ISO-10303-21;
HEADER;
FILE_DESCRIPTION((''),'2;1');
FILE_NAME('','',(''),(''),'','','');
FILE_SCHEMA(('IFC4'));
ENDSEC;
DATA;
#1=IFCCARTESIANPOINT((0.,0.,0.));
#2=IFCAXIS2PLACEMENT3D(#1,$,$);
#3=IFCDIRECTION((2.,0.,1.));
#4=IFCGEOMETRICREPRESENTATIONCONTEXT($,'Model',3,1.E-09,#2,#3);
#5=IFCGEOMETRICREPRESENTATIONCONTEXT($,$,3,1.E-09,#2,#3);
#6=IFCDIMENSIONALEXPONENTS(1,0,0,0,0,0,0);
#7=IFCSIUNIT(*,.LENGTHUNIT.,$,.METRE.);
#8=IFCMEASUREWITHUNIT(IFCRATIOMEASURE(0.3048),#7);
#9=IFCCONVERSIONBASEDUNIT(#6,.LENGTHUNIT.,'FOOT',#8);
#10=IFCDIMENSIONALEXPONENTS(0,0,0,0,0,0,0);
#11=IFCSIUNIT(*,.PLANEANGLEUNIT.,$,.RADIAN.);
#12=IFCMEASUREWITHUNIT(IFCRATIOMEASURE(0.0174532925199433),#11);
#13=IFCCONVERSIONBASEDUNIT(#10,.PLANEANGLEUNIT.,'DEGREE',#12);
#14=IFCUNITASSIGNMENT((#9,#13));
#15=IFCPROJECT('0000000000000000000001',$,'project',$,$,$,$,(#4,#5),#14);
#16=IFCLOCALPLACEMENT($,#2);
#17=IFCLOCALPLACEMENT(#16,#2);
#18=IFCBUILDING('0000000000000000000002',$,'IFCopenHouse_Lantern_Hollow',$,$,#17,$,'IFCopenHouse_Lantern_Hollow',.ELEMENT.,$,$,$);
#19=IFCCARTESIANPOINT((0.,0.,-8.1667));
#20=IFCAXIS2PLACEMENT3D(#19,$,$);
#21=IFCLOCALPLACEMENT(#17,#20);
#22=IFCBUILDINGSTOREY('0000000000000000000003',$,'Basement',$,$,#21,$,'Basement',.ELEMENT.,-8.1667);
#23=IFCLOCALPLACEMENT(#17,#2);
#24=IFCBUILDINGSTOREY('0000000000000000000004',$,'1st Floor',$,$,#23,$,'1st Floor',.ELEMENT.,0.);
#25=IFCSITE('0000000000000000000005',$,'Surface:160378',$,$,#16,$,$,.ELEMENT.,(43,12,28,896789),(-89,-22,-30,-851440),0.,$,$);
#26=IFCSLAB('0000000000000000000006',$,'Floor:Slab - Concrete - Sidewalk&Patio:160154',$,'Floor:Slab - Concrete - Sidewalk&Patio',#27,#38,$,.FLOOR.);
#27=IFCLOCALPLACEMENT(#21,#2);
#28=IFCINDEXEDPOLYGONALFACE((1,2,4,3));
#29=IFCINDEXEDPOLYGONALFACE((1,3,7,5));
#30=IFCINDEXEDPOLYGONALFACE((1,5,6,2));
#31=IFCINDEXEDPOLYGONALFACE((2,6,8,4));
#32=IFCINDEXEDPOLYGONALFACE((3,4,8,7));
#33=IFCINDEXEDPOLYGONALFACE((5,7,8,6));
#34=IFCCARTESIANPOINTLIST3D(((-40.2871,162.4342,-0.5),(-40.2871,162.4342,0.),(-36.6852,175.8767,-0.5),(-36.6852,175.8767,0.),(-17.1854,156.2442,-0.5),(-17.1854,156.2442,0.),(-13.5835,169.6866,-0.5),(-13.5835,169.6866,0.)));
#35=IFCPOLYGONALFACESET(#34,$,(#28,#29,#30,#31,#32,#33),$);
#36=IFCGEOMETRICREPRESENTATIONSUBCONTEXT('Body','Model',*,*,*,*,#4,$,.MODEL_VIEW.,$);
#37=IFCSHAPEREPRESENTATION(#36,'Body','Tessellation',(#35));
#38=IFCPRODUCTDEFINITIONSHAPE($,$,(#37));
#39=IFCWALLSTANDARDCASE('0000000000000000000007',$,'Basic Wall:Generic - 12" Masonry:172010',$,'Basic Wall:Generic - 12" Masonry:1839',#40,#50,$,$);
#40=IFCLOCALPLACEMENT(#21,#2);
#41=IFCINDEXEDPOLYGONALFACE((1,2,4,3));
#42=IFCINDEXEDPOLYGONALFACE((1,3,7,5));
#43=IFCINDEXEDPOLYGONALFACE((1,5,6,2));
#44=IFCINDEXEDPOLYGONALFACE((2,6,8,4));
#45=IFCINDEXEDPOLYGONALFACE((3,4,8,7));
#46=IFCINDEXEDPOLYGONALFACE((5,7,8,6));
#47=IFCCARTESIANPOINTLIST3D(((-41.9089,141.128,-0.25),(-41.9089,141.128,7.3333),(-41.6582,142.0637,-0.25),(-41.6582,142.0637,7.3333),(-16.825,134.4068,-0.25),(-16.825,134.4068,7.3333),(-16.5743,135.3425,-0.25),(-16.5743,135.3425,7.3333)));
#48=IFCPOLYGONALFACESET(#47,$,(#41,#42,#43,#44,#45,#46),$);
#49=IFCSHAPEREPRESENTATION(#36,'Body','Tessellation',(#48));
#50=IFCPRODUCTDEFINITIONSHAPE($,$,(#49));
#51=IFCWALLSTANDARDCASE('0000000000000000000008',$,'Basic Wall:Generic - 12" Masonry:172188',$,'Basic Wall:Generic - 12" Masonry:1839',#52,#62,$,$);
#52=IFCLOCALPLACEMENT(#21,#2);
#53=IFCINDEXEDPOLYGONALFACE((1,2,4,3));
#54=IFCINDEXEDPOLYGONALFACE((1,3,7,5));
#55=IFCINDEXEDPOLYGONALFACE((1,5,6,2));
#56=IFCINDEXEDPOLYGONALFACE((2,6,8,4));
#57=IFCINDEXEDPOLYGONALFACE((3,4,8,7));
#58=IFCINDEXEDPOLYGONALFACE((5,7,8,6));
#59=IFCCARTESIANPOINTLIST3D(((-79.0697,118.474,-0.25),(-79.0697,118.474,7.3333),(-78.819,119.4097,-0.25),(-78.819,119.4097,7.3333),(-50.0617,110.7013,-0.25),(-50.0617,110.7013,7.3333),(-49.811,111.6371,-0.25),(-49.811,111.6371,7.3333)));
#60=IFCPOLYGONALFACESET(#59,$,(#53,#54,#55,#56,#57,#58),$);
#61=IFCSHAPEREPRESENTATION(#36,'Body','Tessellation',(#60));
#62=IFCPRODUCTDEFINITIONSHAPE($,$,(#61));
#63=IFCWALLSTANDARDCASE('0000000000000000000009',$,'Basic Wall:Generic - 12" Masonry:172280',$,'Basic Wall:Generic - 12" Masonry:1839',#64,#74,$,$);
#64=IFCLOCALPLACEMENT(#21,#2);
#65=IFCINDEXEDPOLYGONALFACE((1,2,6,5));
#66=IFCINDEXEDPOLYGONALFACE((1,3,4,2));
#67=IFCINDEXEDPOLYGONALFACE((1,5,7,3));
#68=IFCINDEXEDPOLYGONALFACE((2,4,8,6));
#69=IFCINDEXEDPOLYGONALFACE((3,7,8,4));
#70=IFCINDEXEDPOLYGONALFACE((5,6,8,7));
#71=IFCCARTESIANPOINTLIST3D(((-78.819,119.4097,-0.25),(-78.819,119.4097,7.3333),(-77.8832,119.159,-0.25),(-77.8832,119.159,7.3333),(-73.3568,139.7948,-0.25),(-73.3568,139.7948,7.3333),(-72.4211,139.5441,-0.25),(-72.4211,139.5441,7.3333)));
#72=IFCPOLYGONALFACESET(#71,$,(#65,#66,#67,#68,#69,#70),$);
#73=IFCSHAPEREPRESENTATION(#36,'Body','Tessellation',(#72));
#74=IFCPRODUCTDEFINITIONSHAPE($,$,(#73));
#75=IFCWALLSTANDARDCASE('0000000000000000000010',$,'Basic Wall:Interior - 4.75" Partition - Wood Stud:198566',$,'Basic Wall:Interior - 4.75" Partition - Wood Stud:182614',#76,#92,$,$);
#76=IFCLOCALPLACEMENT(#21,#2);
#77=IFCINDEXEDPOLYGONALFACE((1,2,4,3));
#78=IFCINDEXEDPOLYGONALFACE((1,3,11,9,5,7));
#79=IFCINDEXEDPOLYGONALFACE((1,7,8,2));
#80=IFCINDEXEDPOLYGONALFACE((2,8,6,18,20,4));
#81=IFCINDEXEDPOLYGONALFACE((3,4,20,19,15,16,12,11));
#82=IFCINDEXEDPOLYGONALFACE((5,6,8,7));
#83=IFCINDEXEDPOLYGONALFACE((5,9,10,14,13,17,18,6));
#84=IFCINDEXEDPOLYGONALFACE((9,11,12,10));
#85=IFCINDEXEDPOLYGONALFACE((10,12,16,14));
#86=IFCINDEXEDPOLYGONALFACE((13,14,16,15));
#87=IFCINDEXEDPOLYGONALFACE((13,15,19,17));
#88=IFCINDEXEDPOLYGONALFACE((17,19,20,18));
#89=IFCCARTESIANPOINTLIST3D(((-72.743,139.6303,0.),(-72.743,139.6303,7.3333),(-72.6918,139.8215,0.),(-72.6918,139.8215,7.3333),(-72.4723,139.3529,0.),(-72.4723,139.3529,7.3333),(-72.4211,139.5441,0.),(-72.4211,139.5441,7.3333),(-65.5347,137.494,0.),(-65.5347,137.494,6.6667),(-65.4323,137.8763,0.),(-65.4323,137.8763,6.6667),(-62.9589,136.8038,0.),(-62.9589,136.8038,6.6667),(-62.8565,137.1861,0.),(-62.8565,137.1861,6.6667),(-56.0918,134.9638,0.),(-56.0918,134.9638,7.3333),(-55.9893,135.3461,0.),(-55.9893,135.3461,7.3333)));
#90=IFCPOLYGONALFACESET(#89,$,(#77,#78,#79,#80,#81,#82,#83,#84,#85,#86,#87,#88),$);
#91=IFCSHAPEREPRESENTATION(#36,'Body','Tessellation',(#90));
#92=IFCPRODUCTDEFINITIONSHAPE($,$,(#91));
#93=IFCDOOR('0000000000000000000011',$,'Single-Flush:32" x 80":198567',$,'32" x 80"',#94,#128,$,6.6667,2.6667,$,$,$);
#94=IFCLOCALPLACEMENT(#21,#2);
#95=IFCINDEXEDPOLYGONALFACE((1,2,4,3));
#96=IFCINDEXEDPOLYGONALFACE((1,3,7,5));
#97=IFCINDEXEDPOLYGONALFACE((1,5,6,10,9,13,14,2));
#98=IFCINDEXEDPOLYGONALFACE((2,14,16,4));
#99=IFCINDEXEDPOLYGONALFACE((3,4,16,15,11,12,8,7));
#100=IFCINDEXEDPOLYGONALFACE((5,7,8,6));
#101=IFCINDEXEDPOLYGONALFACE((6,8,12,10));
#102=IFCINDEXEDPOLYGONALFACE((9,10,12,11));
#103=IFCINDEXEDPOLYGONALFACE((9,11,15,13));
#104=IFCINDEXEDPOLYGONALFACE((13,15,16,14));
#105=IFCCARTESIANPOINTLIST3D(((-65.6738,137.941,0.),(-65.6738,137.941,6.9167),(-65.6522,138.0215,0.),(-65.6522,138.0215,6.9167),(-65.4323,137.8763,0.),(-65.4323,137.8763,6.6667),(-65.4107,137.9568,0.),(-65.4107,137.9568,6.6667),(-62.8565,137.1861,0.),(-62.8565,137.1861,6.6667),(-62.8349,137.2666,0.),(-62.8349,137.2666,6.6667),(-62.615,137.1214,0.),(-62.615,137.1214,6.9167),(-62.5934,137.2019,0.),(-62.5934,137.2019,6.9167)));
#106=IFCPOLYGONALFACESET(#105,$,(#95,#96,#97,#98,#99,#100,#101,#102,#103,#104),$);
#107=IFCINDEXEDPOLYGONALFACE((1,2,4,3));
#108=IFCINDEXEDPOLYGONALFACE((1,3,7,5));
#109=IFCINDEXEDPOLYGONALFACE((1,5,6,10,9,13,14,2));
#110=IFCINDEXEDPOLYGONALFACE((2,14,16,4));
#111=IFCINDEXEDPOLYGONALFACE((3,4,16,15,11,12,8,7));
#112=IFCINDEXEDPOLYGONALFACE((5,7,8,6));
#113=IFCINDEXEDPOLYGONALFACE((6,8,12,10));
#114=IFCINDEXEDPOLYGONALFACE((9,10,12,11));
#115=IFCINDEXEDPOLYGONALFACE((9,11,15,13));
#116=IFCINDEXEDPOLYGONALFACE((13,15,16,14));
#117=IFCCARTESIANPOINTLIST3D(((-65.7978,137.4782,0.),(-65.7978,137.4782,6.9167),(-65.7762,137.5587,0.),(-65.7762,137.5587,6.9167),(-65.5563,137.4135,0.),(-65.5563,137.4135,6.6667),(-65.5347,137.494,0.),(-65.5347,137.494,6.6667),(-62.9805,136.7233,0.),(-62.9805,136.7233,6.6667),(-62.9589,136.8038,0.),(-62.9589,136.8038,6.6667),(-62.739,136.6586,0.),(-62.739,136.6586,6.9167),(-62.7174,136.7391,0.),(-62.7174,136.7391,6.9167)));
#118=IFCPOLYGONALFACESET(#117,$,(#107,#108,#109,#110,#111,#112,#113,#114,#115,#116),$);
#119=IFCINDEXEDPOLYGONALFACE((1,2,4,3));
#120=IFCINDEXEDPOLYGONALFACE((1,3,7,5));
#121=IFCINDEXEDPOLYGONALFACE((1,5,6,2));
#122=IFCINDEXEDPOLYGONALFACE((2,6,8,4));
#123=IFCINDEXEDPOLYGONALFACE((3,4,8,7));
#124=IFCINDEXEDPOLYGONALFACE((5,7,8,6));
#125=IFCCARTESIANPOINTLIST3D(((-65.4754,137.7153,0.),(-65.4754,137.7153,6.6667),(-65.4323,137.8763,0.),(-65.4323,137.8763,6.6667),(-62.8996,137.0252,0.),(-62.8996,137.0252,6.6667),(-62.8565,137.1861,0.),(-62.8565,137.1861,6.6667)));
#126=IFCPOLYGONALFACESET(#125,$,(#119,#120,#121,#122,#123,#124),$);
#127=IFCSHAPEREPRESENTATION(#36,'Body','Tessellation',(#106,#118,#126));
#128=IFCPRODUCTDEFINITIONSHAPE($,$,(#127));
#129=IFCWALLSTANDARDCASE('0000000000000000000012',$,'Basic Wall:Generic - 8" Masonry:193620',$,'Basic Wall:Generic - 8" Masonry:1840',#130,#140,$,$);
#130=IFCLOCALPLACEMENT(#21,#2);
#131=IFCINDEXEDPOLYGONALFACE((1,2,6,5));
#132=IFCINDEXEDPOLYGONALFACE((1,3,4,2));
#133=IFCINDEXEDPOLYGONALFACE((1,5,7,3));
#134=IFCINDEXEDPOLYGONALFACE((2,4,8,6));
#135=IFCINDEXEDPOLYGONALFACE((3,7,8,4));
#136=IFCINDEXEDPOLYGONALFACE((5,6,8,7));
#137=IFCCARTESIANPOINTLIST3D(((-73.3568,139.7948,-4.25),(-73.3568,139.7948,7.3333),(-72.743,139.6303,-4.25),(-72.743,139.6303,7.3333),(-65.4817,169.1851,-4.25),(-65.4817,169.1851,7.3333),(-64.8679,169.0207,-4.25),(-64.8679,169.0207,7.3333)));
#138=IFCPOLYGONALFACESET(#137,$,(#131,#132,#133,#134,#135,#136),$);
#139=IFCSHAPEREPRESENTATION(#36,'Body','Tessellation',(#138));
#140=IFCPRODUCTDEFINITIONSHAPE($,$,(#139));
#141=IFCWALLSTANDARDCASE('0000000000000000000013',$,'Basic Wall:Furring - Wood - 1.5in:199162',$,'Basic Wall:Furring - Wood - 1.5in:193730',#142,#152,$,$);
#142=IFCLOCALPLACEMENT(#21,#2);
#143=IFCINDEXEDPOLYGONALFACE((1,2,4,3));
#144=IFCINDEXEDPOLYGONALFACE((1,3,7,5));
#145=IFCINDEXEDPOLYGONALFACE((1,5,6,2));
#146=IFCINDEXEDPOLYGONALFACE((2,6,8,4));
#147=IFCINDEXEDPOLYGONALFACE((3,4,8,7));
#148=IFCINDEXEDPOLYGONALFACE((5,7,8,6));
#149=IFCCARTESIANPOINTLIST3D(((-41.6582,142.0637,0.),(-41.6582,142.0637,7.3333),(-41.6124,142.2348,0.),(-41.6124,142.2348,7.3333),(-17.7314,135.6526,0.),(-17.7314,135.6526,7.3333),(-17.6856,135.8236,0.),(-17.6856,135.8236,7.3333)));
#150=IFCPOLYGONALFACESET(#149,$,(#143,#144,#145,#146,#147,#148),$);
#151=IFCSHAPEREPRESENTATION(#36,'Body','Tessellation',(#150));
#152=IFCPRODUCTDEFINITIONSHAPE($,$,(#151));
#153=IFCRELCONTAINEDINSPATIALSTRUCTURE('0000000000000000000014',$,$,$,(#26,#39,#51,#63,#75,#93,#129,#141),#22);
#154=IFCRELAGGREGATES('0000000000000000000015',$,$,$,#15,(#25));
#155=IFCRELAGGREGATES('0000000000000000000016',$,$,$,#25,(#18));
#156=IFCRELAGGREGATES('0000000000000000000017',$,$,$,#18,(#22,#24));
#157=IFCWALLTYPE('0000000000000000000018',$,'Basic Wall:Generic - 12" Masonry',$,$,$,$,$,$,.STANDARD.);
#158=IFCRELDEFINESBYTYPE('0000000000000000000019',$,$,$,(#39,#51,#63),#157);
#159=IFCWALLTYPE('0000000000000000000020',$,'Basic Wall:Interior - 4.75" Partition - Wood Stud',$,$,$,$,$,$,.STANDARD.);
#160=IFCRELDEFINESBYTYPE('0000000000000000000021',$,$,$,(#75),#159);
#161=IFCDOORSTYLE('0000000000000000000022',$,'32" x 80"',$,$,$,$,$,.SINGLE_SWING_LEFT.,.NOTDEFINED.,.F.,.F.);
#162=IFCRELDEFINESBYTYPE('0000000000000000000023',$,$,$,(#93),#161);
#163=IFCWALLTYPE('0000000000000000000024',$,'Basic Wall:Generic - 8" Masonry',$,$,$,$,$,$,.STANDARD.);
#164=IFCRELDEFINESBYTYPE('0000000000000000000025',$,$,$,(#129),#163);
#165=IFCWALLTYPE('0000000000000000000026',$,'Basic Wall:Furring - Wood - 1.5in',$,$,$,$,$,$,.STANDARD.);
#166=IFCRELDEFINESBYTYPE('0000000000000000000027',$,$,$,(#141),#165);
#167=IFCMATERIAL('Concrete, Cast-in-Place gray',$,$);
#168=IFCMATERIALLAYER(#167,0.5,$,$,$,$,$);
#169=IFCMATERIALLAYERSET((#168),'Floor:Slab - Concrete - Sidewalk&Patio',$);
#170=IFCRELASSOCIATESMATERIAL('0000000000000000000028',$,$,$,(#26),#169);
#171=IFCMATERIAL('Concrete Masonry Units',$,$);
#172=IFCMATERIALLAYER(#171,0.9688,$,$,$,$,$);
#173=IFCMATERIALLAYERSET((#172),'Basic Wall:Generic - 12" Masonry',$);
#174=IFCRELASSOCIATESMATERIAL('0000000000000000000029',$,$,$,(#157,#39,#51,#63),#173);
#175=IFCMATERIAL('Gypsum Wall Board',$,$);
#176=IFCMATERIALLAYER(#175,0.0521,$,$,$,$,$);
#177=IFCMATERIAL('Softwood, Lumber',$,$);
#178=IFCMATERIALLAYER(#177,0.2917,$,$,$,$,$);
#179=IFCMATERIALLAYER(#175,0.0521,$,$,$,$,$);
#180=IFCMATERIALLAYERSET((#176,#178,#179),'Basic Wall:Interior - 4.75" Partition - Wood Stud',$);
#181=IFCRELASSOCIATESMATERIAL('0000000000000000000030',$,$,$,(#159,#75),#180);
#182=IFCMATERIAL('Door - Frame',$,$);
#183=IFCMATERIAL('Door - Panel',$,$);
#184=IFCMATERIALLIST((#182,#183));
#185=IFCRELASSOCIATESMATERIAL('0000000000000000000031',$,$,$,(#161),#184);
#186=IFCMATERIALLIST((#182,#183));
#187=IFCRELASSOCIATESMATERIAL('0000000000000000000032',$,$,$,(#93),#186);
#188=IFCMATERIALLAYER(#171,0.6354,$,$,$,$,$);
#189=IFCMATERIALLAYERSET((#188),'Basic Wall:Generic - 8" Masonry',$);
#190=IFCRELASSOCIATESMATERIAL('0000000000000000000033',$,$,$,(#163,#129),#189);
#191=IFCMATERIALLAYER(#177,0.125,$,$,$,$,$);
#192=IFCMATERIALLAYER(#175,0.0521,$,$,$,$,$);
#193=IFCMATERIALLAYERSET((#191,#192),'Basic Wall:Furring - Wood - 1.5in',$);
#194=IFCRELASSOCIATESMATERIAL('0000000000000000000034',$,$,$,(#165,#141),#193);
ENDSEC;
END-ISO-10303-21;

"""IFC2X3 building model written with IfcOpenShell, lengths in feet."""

from ifc_helpers import new_model, entity, si_unit, converted_unit, direction, frame, frame_2d, origin, origin_2d_with_axis, place, context, subcontext, project, spatial, polyline, rectangle, outline, extrude, source, transform, mapped, material, material_list, layer, layer_set, layer_usage, type_object, type_shapes, element, fill, save


model = new_model("IFC2X3")

# Units and contexts
model_context = context("Model", 3, precision=1e-09, world=origin(), true_north=direction((2.0, 0.0, 1.0)))
context_of_model = context(None, 3, precision=1e-09, world=origin(), true_north=direction((2.0, 0.0, 1.0)))
body_context = subcontext(model_context, "Body", "Model", "MODEL_VIEW")
ifc_project = project(units=[converted_unit("LENGTHUNIT", "FOOT", entity("IfcRatioMeasure", 0.3048), si_unit("LENGTHUNIT", "METRE"), dimensions=[1, 0, 0, 0, 0, 0, 0]), converted_unit("PLANEANGLEUNIT", "DEGREE", entity("IfcRatioMeasure", 0.0174532925199433), si_unit("PLANEANGLEUNIT", "RADIAN"), dimensions=[0, 0, 0, 0, 0, 0, 0])], contexts=[model_context, context_of_model])

# Site, building, storey
site_placement = place(None, origin())
site = spatial("IfcSite", under=ifc_project, at=site_placement, Name="Surface:160378", CompositionType="ELEMENT", RefLatitude=(43, 12, 28, 896789), RefLongitude=(-89, -22, -30, -851440), RefElevation=0.0)
building_placement = place(site_placement, origin())
building = spatial("IfcBuilding", under=site, at=building_placement, Name="IFCopenHouse_Lantern_Hollow", LongName="IFCopenHouse_Lantern_Hollow", CompositionType="ELEMENT")
storey_1_placement = place(building_placement, frame((0.0, 0.0, -8.1667)))
storey_1 = spatial("IfcBuildingStorey", under=building, at=storey_1_placement, Name="Basement", LongName="Basement", CompositionType="ELEMENT", Elevation=-8.1667)

# Shared definitions
ifc_material_1 = material(Name="Concrete, Cast-in-Place gray")

# Slab
ifc_layer_1 = layer(ifc_material_1, 0.5)
ifc_layer_set_1 = layer_set([ifc_layer_1], Name="Floor:Slab - Concrete - Sidewalk&Patio")
ifc_layer_usage_1 = layer_usage(ifc_layer_set_1, "AXIS3", "POSITIVE", 0.0)
slab_1_placement = place(storey_1_placement, origin())
element("IfcSlab", 1, at=slab_1_placement, inside=storey_1, material=ifc_layer_usage_1, Name="Floor:Slab - Concrete - Sidewalk&Patio:160154", ObjectType="Floor:Slab - Concrete - Sidewalk&Patio", PredefinedType="FLOOR", context=body_context, shape_type="SweptSolid", body=[
    extrude(rectangle(XDim=13.9167, YDim=23.9167, at=frame_2d((0.0, 0.0), x_axis=(1.0, 0.0))), frame((-26.9353, 166.0604, 0.0), z_axis=(0.0, 0.0, -1.0), x_axis=(-0.258819, -0.965926, 0.0)), (0.0, 0.0, 1.0), 0.5),
])

# Walls
ifc_material_2 = material(Name="Concrete Masonry Units")
ifc_layer_2 = layer(ifc_material_2, 0.9688)
ifc_layer_set_2 = layer_set([ifc_layer_2], Name="Basic Wall:Generic - 12\" Masonry")
ifc_layer_usage_2 = layer_usage(ifc_layer_set_2, "AXIS2", "NEGATIVE", 0.4844)
wall_type_1 = type_object("IfcWallType", Name="Basic Wall:Generic - 12\" Masonry", PredefinedType="STANDARD", material=ifc_layer_set_2)
wall_1_placement = place(storey_1_placement, frame((-16.6997, 134.8747, -0.25), z_axis=(0.0, 0.0, 1.0), x_axis=(-0.965926, 0.258819, 0.0)))
element("IfcWallStandardCase", 2, at=wall_1_placement, inside=storey_1, type_object=wall_type_1, material=ifc_layer_usage_2, Name="Basic Wall:Generic - 12\" Masonry:172010", ObjectType="Basic Wall:Generic - 12\" Masonry:1839", context=body_context, shape_type="SweptSolid", body=[
    extrude(rectangle(XDim=25.9687, YDim=0.9688, at=frame_2d((12.9844, 0.0), x_axis=(-1.0, 0.0))), origin(), (0.0, 0.0, 1.0), 7.5833),
])
ifc_layer_usage_3 = layer_usage(ifc_layer_set_2, "AXIS2", "NEGATIVE", 0.4844)
wall_2_placement = place(storey_1_placement, frame((-49.9364, 111.1692, -0.25), z_axis=(0.0, 0.0, 1.0), x_axis=(-0.965926, 0.258819, 0.0)))
element("IfcWallStandardCase", 3, at=wall_2_placement, inside=storey_1, type_object=wall_type_1, material=ifc_layer_usage_3, Name="Basic Wall:Generic - 12\" Masonry:172188", ObjectType="Basic Wall:Generic - 12\" Masonry:1839", context=body_context, shape_type="SweptSolid", body=[
    extrude(rectangle(XDim=30.0313, YDim=0.9687, at=frame_2d((15.0156, 0.0), x_axis=(-1.0, 0.0))), origin(), (0.0, 0.0, 1.0), 7.5833),
])
ifc_layer_usage_4 = layer_usage(ifc_layer_set_2, "AXIS2", "NEGATIVE", 0.4844)
wall_3_placement = place(storey_1_placement, frame((-78.3511, 119.2844, -0.25), z_axis=(0.0, 0.0, 1.0), x_axis=(0.258819, 0.965926, 0.0)))
element("IfcWallStandardCase", 4, at=wall_3_placement, inside=storey_1, type_object=wall_type_1, material=ifc_layer_usage_4, Name="Basic Wall:Generic - 12\" Masonry:172280", ObjectType="Basic Wall:Generic - 12\" Masonry:1839", context=body_context, shape_type="SweptSolid", body=[
    extrude(rectangle(XDim=21.1042, YDim=0.9687, at=frame_2d((10.5521, 0.0), x_axis=(-1.0, 0.0))), origin(), (0.0, 0.0, 1.0), 7.5833),
])

# Wall, opening, door
ifc_material_3 = material(Name="Gypsum Wall Board")
ifc_layer_3 = layer(ifc_material_3, 0.0521)
ifc_material_4 = material(Name="Softwood, Lumber")
ifc_layer_4 = layer(ifc_material_4, 0.2917)
ifc_layer_5 = layer(ifc_material_3, 0.0521)
ifc_layer_set_3 = layer_set([ifc_layer_3, ifc_layer_4, ifc_layer_5], Name="Basic Wall:Interior - 4.75\" Partition - Wood Stud")
ifc_layer_usage_5 = layer_usage(ifc_layer_set_3, "AXIS2", "NEGATIVE", 0.1979)
wall_type_2 = type_object("IfcWallType", Name="Basic Wall:Interior - 4.75\" Partition - Wood Stud", PredefinedType="STANDARD", material=ifc_layer_set_3)
wall_4_placement = place(storey_1_placement, frame((-72.743, 139.6303, 0.0), z_axis=(0.0, 0.0, 1.0), x_axis=(0.965926, -0.258819, 0.0)))
wall_4 = element("IfcWallStandardCase", 5, at=wall_4_placement, inside=storey_1, type_object=wall_type_2, material=ifc_layer_usage_5, Name="Basic Wall:Interior - 4.75\" Partition - Wood Stud:198566", ObjectType="Basic Wall:Interior - 4.75\" Partition - Wood Stud:182614", context=body_context, shape_type="SweptSolid", body=[
    extrude(outline(polyline([(0.3333, -0.1979), (17.2917, -0.1979), (17.2917, 0.1979), (16.8958, 0.1979), (0.0, 0.1979), (0.0, 0.0), (0.3333, 0.0), (0.3333, -0.1979)])), origin(), (0.0, 0.0, 1.0), 7.3333),
])
opening_1_placement = place(wall_4_placement, frame((7.5156, -0.1979, 0.0)))
opening_1 = element("IfcOpeningElement", 6, at=opening_1_placement, cuts=wall_4, ObjectType="Opening", context=body_context, shape_type="SweptSolid", body=[
    extrude(rectangle(XDim=2.6667, YDim=6.6667, at=frame_2d((3.3333, 1.3333), x_axis=(0.0, -1.0))), frame((0.0, 0.0, 0.0), z_axis=(0.0, 1.0, 0.0), x_axis=(0.0, 0.0, 1.0)), (0.0, 0.0, 1.0), 0.3958),
])
ifc_material_5 = material(Name="Door - Frame")
ifc_material_6 = material(Name="Door - Panel")
ifc_material_list_1 = material_list([ifc_material_5, ifc_material_6])
ifc_material_list_2 = material_list([ifc_material_5, ifc_material_6])
door_style_1 = type_object("IfcDoorStyle", Name="32\" x 80\"", ConstructionType="NOTDEFINED", OperationType="SINGLE_SWING_LEFT", ParameterTakesPrecedence=False, Sizeable=False, material=ifc_material_list_2)
shared_shape_1 = source(origin(), body_context, "Body", "SweptSolid", [
    extrude(outline(polyline([(-1.5833, -3.5208), (1.5833, -3.5208), (1.5833, 3.3958), (1.3333, 3.3958), (1.3333, -3.2708), (-1.3333, -3.2708), (-1.3333, 3.3958), (-1.5833, 3.3958), (-1.5833, -3.5208)])), frame((1.3333, 0.4792, 3.3958), z_axis=(0.0, -1.0, 0.0), x_axis=(-1.0, 0.0, 0.0)), (0.0, 0.0, 1.0), 0.0833),
    extrude(outline(polyline([(-3.5208, -1.5833), (3.3958, -1.5833), (3.3958, -1.3333), (-3.2708, -1.3333), (-3.2708, 1.3333), (3.3958, 1.3333), (3.3958, 1.5833), (-3.5208, 1.5833), (-3.5208, -1.5833)])), frame((1.3333, 0.0, 3.3958), z_axis=(0.0, -1.0, 0.0), x_axis=(0.0, 0.0, -1.0)), (0.0, 0.0, 1.0), 0.0833),
    extrude(rectangle(XDim=2.6667, YDim=0.1667, at=origin_2d_with_axis()), frame((1.3333, 0.3125, 0.0)), (0.0, 0.0, 1.0), 6.6667),
])
type_shapes(door_style_1, [shared_shape_1])
door_1_placement = place(storey_1_placement, frame((-65.5347, 137.494, 0.0), z_axis=(0.0, 0.0, 1.0), x_axis=(0.965926, -0.258819, 0.0)))
door_1 = element("IfcDoor", 7, at=door_1_placement, inside=storey_1, type_object=door_style_1, material=ifc_material_list_1, Name="Single-Flush:32\" x 80\":198567", ObjectType="32\" x 80\"", OverallHeight=6.6667, OverallWidth=2.6667, context=body_context, shape_type="MappedRepresentation", body=[
    mapped(shared_shape_1, transform((0.0, 0.0, 0.0), scale=1.0)),
])
fill(opening_1, door_1)

# Walls
ifc_layer_6 = layer(ifc_material_2, 0.6354)
ifc_layer_set_4 = layer_set([ifc_layer_6], Name="Basic Wall:Generic - 8\" Masonry")
ifc_layer_usage_6 = layer_usage(ifc_layer_set_4, "AXIS2", "NEGATIVE", 0.3177)
wall_type_3 = type_object("IfcWallType", Name="Basic Wall:Generic - 8\" Masonry", PredefinedType="STANDARD", material=ifc_layer_set_4)
wall_5_placement = place(storey_1_placement, frame((-73.0499, 139.7126, -4.25), z_axis=(0.0, 0.0, 1.0), x_axis=(0.258819, 0.965926, 0.0)))
element("IfcWallStandardCase", 8, at=wall_5_placement, inside=storey_1, type_object=wall_type_3, material=ifc_layer_usage_6, Name="Basic Wall:Generic - 8\" Masonry:193620", ObjectType="Basic Wall:Generic - 8\" Masonry:1840", context=body_context, shape_type="SweptSolid", body=[
    extrude(rectangle(XDim=30.4271, YDim=0.6354, at=frame_2d((15.2135, 0.0), x_axis=(-1.0, 0.0))), origin(), (0.0, 0.0, 1.0), 11.5833),
])
ifc_layer_7 = layer(ifc_material_4, 0.125)
ifc_layer_8 = layer(ifc_material_3, 0.0521)
ifc_layer_set_5 = layer_set([ifc_layer_7, ifc_layer_8], Name="Basic Wall:Furring - Wood - 1.5in")
ifc_layer_usage_7 = layer_usage(ifc_layer_set_5, "AXIS2", "NEGATIVE", 0.0885)
wall_type_4 = type_object("IfcWallType", Name="Basic Wall:Furring - Wood - 1.5in", PredefinedType="STANDARD", material=ifc_layer_set_5)
wall_6_placement = place(storey_1_placement, frame((-17.7085, 135.7381, 0.0), z_axis=(0.0, 0.0, 1.0), x_axis=(-0.965926, 0.258819, 0.0)))
element("IfcWallStandardCase", 9, at=wall_6_placement, inside=storey_1, type_object=wall_type_4, material=ifc_layer_usage_7, Name="Basic Wall:Furring - Wood - 1.5in:199162", ObjectType="Basic Wall:Furring - Wood - 1.5in:193730", context=body_context, shape_type="SweptSolid", body=[
    extrude(rectangle(XDim=24.7708, YDim=0.1771, at=frame_2d((12.3854, 0.0), x_axis=(-1.0, 0.0))), origin(), (0.0, 0.0, 1.0), 7.3333),
])

# Shared definitions
storey_2_placement = place(building_placement, origin())
storey_2 = spatial("IfcBuildingStorey", under=building, at=storey_2_placement, Name="1st Floor", LongName="1st Floor", CompositionType="ELEMENT", Elevation=0.0)

save(model, "model.ifc")
